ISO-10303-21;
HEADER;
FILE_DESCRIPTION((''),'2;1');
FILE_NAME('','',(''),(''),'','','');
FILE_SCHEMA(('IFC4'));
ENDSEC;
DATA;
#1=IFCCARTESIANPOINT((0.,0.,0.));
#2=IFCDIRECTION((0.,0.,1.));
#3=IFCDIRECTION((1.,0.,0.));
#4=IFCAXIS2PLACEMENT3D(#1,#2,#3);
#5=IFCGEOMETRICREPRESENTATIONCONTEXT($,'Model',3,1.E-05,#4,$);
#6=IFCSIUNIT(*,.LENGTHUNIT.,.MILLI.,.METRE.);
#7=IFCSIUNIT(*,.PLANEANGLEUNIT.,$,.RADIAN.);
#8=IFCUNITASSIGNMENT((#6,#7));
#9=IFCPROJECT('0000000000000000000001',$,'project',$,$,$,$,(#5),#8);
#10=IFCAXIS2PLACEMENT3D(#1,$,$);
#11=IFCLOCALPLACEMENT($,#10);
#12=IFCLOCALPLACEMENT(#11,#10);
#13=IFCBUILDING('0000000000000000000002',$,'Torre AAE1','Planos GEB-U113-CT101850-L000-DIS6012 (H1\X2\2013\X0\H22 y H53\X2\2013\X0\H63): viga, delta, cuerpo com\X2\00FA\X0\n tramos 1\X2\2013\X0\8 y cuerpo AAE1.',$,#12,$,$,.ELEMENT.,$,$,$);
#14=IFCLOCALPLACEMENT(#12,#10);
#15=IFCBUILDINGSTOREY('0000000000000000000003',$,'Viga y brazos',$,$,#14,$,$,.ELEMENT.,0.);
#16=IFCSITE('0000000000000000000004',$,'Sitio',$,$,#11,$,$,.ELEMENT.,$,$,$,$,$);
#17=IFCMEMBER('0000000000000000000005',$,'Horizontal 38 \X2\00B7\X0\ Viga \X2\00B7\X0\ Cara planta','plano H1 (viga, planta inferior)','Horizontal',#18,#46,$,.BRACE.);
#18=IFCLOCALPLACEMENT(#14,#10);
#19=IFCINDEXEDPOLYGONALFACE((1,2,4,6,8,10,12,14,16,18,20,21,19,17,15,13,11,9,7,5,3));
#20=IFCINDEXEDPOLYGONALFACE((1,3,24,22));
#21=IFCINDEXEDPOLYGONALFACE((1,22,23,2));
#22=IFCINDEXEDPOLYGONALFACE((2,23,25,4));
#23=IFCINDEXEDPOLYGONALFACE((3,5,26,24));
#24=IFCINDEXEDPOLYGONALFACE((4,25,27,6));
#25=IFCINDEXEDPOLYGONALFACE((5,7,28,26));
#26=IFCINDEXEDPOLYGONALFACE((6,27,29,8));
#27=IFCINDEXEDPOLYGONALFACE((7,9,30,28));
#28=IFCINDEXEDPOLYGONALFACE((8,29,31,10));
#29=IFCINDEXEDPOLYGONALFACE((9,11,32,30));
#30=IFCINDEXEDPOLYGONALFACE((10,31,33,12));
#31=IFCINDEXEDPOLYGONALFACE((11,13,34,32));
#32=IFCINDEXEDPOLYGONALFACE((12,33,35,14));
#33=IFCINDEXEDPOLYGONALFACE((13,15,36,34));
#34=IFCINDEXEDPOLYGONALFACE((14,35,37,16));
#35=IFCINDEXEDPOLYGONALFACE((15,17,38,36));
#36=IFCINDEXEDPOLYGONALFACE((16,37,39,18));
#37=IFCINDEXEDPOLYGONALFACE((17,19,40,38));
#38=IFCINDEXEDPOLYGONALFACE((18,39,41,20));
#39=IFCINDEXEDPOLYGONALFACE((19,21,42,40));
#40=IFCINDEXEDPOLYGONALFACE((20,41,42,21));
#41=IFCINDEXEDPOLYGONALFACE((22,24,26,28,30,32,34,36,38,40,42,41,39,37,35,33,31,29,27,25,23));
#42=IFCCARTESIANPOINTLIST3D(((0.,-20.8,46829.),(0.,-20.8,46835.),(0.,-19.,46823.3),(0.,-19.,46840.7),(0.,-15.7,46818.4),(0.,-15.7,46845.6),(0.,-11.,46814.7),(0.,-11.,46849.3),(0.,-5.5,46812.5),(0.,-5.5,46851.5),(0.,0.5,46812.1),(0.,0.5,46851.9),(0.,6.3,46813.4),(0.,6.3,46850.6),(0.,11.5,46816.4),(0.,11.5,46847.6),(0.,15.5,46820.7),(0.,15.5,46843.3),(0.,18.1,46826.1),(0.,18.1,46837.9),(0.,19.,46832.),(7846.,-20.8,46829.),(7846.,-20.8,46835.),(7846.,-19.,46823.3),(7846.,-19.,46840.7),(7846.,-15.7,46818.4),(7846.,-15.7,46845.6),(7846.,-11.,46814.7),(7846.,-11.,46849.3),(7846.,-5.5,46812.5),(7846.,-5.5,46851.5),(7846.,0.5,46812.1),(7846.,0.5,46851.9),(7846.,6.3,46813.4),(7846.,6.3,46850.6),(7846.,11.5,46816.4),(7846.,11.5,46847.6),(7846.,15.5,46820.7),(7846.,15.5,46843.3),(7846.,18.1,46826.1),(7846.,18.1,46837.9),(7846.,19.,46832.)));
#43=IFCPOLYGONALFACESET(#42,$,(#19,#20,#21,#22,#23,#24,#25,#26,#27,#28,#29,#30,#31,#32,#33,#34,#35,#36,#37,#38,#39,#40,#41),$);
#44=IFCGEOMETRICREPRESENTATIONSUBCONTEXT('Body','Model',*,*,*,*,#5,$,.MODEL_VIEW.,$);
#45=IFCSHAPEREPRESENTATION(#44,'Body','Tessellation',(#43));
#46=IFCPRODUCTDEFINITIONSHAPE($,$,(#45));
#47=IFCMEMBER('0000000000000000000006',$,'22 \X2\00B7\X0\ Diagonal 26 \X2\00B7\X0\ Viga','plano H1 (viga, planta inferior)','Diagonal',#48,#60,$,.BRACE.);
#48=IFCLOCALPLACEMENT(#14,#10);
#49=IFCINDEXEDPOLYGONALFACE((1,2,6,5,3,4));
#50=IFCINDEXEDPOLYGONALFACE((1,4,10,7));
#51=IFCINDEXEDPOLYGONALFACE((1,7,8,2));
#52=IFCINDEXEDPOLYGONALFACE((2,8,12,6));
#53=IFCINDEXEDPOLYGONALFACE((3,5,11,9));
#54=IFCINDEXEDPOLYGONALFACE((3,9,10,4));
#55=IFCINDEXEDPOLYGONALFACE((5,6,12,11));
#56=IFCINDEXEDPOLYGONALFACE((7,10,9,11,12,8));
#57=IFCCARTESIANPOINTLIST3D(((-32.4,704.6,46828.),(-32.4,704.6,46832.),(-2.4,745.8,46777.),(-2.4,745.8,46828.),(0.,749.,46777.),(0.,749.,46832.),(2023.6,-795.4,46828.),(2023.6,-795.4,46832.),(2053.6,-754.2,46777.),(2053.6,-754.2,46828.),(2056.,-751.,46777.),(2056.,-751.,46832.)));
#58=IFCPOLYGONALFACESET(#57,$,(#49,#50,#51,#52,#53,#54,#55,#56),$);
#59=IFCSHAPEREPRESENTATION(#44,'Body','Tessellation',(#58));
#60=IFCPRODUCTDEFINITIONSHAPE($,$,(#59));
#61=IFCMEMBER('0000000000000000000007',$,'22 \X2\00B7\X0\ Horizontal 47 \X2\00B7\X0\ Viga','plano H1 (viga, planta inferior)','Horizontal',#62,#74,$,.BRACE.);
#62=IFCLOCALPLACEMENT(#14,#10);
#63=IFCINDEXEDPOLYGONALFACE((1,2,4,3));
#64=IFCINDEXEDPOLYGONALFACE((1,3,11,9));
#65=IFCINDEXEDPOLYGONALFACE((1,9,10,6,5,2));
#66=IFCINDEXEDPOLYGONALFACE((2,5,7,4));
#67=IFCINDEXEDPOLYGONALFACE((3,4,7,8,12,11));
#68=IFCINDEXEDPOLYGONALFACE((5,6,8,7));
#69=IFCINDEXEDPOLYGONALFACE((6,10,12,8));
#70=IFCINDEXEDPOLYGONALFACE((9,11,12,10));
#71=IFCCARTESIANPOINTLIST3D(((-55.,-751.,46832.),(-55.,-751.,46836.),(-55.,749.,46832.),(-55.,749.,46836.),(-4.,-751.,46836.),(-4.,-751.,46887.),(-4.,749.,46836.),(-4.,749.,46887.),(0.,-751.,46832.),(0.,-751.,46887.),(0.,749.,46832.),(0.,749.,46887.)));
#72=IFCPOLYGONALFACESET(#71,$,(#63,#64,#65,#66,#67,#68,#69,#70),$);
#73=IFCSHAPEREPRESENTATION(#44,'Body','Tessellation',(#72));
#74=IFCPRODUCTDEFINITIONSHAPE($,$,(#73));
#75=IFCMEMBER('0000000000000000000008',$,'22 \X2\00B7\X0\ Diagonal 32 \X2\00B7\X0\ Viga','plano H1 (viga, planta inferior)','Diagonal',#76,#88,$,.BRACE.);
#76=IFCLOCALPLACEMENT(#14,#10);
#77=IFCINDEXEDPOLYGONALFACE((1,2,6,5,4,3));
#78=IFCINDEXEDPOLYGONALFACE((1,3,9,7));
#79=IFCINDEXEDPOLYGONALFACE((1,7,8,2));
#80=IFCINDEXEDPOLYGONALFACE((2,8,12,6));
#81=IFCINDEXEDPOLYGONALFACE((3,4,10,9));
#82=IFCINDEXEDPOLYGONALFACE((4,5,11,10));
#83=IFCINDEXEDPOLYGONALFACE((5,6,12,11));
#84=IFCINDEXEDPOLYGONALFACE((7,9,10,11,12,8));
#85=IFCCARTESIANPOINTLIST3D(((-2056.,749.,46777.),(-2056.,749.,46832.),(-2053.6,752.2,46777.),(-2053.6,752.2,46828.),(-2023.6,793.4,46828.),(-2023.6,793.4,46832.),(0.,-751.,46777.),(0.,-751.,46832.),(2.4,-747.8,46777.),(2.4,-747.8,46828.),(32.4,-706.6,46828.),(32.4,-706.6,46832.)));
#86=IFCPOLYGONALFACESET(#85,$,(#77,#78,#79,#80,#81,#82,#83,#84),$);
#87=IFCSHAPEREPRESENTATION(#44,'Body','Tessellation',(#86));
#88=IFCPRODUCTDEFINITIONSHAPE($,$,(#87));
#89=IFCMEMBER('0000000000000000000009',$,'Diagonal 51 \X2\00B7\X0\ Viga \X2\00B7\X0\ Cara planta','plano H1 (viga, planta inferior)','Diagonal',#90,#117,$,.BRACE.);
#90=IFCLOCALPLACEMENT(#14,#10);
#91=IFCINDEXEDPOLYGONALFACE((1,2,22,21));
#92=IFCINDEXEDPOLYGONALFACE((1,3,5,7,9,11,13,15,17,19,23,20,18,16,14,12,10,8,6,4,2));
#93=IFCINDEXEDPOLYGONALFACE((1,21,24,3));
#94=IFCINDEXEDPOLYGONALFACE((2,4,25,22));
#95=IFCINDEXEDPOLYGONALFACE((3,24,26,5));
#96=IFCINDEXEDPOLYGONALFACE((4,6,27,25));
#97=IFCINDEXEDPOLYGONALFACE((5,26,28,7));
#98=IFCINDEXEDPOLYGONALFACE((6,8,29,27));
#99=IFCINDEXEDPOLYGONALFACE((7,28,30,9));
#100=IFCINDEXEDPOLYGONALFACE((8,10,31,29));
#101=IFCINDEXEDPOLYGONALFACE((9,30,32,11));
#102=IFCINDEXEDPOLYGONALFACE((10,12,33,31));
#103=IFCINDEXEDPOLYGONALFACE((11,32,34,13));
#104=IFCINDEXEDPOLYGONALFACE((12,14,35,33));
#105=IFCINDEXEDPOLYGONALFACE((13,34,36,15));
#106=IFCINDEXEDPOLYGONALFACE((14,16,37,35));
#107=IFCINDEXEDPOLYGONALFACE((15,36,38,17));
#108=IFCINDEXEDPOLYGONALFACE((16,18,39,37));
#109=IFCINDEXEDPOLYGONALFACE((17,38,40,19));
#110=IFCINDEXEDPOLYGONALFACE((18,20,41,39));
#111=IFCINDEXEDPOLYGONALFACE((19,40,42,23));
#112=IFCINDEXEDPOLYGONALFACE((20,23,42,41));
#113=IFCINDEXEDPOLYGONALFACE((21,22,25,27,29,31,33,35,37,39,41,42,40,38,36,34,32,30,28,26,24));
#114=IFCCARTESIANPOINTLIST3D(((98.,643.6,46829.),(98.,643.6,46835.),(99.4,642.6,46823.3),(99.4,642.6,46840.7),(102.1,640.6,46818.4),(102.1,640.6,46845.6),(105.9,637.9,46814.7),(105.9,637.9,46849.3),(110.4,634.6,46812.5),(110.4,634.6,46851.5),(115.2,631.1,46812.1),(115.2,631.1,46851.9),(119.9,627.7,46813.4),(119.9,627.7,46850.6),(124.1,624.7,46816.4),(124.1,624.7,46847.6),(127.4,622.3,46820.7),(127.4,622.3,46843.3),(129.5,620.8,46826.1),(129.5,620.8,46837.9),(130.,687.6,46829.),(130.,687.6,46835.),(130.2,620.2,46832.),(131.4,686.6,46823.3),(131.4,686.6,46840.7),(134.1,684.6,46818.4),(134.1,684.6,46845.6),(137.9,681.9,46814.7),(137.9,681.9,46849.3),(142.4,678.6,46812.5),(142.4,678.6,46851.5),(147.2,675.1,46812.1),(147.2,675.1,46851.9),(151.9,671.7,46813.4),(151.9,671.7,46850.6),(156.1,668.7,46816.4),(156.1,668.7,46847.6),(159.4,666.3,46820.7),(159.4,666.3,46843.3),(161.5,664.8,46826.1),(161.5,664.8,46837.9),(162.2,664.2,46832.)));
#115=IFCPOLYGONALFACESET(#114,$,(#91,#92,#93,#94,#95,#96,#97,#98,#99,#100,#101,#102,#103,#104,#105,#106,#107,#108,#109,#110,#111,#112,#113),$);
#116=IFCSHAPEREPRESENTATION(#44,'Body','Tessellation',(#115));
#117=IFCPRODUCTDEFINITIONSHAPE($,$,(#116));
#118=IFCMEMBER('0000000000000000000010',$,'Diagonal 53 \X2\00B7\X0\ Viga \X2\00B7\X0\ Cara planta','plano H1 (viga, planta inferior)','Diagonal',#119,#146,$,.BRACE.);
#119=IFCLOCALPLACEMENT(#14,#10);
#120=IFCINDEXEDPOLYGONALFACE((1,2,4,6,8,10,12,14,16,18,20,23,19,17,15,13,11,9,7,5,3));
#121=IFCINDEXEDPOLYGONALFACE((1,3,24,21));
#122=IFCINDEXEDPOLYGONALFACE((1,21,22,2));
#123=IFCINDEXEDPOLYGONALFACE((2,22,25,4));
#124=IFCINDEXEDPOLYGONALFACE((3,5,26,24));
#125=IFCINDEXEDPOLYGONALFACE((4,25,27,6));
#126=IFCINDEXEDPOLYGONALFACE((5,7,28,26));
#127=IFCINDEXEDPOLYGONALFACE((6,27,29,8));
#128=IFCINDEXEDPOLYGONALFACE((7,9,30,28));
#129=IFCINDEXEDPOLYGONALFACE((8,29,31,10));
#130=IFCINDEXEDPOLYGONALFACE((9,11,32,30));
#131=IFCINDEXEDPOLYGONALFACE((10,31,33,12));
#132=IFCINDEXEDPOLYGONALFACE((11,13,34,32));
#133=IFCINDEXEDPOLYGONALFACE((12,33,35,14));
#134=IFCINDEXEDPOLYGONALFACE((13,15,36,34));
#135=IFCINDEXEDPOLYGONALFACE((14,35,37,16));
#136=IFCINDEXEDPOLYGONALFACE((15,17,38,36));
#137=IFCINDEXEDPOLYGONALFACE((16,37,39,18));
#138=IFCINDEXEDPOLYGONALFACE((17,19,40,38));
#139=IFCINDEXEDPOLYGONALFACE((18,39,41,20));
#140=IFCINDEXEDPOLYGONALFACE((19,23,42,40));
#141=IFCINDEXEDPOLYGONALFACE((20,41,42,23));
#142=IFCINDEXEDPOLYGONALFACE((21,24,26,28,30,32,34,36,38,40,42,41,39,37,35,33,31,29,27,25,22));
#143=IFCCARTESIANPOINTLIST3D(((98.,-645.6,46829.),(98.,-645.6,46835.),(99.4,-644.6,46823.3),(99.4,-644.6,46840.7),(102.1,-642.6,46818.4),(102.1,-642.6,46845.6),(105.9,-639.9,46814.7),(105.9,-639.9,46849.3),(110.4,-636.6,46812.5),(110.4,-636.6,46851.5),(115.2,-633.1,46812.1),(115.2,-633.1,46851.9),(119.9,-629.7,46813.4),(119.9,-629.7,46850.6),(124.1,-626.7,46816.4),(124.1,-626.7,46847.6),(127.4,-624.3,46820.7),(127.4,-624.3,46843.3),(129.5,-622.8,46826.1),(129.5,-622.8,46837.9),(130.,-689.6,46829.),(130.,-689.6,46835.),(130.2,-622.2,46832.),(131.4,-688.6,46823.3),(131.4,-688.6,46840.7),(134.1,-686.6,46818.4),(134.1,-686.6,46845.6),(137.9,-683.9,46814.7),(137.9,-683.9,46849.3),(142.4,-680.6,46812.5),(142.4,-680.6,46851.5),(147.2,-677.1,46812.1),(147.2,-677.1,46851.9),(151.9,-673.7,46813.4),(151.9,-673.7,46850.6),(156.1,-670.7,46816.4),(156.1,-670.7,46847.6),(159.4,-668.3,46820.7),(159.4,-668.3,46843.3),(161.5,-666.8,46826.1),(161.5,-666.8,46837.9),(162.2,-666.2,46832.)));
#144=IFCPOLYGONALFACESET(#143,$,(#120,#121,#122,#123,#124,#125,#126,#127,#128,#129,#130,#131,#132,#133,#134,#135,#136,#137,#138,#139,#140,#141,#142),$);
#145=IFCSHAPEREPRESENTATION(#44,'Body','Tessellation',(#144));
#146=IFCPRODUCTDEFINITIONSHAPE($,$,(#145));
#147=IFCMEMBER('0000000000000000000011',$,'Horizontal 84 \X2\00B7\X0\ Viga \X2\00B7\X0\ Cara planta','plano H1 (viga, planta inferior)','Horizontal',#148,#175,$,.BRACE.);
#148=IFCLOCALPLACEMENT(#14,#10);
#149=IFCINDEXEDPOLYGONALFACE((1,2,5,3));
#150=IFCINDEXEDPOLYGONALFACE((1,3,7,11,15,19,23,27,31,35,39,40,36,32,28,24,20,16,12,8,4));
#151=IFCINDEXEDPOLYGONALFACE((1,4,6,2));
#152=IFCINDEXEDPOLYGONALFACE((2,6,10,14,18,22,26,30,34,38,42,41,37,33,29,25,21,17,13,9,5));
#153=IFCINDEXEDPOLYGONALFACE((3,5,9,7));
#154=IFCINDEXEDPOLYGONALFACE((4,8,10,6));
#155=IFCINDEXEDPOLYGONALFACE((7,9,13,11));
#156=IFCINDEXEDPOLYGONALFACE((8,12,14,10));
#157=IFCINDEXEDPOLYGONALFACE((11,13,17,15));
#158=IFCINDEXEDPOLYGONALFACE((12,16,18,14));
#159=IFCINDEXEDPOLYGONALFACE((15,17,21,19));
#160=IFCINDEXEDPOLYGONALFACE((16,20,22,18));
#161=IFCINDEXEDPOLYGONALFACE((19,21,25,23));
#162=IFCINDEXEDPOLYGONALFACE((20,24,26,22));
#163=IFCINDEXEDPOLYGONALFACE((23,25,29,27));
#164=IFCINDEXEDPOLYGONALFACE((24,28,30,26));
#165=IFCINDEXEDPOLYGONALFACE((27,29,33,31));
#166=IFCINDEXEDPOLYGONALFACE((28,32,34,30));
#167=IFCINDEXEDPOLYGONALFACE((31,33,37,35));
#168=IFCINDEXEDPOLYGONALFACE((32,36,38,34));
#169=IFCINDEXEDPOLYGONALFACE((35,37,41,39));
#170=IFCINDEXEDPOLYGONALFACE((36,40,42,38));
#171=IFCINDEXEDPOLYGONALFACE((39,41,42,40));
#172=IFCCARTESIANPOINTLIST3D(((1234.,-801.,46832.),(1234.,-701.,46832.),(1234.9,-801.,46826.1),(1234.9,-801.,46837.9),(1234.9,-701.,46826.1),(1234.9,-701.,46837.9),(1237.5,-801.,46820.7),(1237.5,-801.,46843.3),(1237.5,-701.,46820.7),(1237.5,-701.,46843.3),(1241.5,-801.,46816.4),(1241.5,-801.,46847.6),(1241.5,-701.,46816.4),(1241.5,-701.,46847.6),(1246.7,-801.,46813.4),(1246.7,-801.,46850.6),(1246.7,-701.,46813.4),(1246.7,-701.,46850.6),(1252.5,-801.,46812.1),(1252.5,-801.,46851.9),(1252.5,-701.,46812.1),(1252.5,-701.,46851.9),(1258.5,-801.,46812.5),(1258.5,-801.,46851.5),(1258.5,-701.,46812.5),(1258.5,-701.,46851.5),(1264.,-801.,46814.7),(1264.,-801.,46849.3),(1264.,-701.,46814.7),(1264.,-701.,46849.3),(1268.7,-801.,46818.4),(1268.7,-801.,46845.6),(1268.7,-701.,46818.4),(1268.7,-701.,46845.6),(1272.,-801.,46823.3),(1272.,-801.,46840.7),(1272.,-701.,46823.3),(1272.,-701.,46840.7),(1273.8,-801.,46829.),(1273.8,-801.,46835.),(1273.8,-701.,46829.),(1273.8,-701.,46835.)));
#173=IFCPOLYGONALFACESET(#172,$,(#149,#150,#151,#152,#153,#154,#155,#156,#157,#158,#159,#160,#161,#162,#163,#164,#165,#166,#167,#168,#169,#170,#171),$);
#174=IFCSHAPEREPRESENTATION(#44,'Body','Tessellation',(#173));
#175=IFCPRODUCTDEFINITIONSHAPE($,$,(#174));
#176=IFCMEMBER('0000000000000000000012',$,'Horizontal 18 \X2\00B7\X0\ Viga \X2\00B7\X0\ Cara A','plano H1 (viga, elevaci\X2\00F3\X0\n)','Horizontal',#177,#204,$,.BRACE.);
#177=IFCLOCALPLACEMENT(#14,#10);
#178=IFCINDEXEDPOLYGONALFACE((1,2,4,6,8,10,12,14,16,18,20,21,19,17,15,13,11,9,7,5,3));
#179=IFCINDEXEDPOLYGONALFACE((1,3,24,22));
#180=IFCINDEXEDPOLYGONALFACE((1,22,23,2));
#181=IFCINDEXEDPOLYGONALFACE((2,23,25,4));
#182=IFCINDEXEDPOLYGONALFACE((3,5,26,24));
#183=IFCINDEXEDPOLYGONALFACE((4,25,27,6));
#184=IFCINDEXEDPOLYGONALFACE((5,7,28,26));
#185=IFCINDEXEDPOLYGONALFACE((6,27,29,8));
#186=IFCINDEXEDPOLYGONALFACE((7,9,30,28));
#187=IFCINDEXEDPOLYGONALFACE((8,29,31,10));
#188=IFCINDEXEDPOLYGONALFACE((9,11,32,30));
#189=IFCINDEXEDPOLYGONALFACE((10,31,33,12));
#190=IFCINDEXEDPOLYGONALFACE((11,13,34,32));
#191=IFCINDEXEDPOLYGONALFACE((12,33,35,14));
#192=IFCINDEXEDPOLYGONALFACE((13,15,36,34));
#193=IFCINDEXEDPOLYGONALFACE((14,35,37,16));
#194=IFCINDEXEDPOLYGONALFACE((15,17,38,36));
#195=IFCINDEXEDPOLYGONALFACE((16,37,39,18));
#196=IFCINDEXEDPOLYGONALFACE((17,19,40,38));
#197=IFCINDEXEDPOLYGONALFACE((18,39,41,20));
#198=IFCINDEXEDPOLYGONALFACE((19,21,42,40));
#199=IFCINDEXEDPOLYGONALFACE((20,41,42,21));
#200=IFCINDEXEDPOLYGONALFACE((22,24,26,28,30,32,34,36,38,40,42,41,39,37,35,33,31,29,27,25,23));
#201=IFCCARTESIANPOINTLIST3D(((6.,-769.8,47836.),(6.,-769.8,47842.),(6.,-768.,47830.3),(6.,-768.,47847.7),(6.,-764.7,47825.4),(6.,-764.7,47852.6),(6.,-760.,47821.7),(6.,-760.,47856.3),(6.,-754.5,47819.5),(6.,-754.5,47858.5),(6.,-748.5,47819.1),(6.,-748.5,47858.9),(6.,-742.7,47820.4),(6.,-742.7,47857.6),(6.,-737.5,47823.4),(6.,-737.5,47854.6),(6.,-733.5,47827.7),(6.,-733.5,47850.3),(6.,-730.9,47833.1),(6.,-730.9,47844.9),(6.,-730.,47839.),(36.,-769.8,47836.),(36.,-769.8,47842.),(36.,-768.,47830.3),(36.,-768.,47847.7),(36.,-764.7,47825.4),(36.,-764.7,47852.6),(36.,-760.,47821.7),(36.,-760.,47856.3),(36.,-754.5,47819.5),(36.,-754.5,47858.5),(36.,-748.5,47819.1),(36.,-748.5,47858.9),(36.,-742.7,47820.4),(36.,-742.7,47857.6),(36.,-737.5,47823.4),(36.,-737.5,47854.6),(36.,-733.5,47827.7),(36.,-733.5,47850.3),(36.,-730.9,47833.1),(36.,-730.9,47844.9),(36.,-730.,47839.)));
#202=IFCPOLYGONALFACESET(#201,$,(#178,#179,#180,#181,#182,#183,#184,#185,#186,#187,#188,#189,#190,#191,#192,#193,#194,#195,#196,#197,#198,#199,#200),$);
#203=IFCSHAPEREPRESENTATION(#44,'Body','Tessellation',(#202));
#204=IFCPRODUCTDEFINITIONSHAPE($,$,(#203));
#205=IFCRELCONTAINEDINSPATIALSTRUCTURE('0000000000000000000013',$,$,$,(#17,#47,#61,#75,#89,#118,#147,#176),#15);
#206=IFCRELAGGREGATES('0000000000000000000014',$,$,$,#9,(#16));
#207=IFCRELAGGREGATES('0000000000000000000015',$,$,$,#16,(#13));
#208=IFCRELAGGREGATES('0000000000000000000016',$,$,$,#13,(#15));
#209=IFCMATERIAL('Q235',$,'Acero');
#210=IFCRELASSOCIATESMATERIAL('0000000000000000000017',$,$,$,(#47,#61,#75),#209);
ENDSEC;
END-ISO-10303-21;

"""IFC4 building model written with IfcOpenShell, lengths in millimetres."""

from ifc_helpers import new_model, si_unit, frame, frame_2d, origin, origin_with_axes, place, context, subcontext, project, spatial, circle, l_section, extrude, material, element, save


model = new_model("IFC4")

# Units and contexts
model_context = context("Model", 3, precision=1e-05, world=origin_with_axes())
body_context = subcontext(model_context, "Body", "Model", "MODEL_VIEW")
ifc_project = project(units=[si_unit("LENGTHUNIT", "METRE", prefix="MILLI"), si_unit("PLANEANGLEUNIT", "RADIAN")], contexts=[model_context])

# Site, building, storey
site_placement = place(None, origin())
site = spatial("IfcSite", under=ifc_project, at=site_placement, Name="Sitio", CompositionType="ELEMENT")
building_placement = place(site_placement, origin())
building = spatial("IfcBuilding", under=site, at=building_placement, Name="Torre AAE1", Description="Planos GEB-U113-CT101850-L000-DIS6012 (H1–H22 y H53–H63): viga, delta, cuerpo común tramos 1–8 y cuerpo AAE1.", CompositionType="ELEMENT")
storey_placement = place(building_placement, origin())
storey = spatial("IfcBuildingStorey", under=building, at=storey_placement, Name="Viga y brazos", CompositionType="ELEMENT", Elevation=0.0)

# Members
ifc_material = material(Name="Q235", Category="Acero")
member_1_placement = place(storey_placement, frame((0.0, -1.0, 46832.0), z_axis=(1.0, 0.0, 0.0), x_axis=(0.0, 1.0, 0.0)))
element("IfcMember", 1, at=member_1_placement, inside=storey, Name="Horizontal 38 · Viga · Cara planta", Description="plano H1 (viga, planta inferior)", ObjectType="Horizontal", PredefinedType="BRACE", context=body_context, shape_type="SweptSolid", body=[
    extrude(circle(Radius=20.0), None, (0.0, 0.0, 1.0), 7846.0),
])
member_2_placement = place(storey_placement, frame((0.0, 749.0, 46832.0), z_axis=(0.807852, -0.589386, 0.0), x_axis=(-0.589386, -0.807852, 0.0)))
element("IfcMember", 2, at=member_2_placement, inside=storey, material=ifc_material, Name="22 · Diagonal 26 · Viga", Description="plano H1 (viga, planta inferior)", ObjectType="Diagonal", PredefinedType="BRACE", context=body_context, shape_type="SweptSolid", body=[
    extrude(l_section(Depth=55.0, Width=55.0, Thickness=4.0, at=frame_2d((27.5, 27.5))), None, (0.0, 0.0, 1.0), 2545.0),
])
member_3_placement = place(storey_placement, frame((0.0, 749.0, 46832.0), z_axis=(0.0, -1.0, 0.0), x_axis=(0.0, 0.0, 1.0)))
element("IfcMember", 3, at=member_3_placement, inside=storey, material=ifc_material, Name="22 · Horizontal 47 · Viga", Description="plano H1 (viga, planta inferior)", ObjectType="Horizontal", PredefinedType="BRACE", context=body_context, shape_type="SweptSolid", body=[
    extrude(l_section(Depth=55.0, Width=55.0, Thickness=4.0, at=frame_2d((27.5, 27.5))), None, (0.0, 0.0, 1.0), 1500.0),
])
member_4_placement = place(storey_placement, frame((0.0, -751.0, 46832.0), z_axis=(-0.807852, 0.589386, 0.0), x_axis=(0.589386, 0.807852, 0.0)))
element("IfcMember", 4, at=member_4_placement, inside=storey, material=ifc_material, Name="22 · Diagonal 32 · Viga", Description="plano H1 (viga, planta inferior)", ObjectType="Diagonal", PredefinedType="BRACE", context=body_context, shape_type="SweptSolid", body=[
    extrude(l_section(Depth=55.0, Width=55.0, Thickness=4.0, at=frame_2d((27.5, 27.5))), None, (0.0, 0.0, 1.0), 2545.0),
])
for number, where, z_axis, x_axis, name in (
    (5, (146.0, 676.0, 46832.0), (-0.588172, -0.808736, 0.0), (0.808736, -0.588172, 0.0), "Diagonal 51 · Viga · Cara planta"),
    (6, (146.0, -678.0, 46832.0), (-0.588172, 0.808736, 0.0), (0.808736, 0.588172, 0.0), "Diagonal 53 · Viga · Cara planta"),
):
    element("IfcMember", number, at=place(storey_placement, frame(where, z_axis=z_axis, x_axis=x_axis)), inside=storey, Name=name, Description="plano H1 (viga, planta inferior)", ObjectType="Diagonal", PredefinedType="BRACE", context=body_context, shape_type="SweptSolid", body=[
        extrude(circle(Radius=20.0), None, (0.0, 0.0, 1.0), 54.4),
    ])
member_5_placement = place(storey_placement, frame((1254.0, -701.0, 46832.0), z_axis=(0.0, -1.0, 0.0), x_axis=(-1.0, 0.0, 0.0)))
element("IfcMember", 7, at=member_5_placement, inside=storey, Name="Horizontal 84 · Viga · Cara planta", Description="plano H1 (viga, planta inferior)", ObjectType="Horizontal", PredefinedType="BRACE", context=body_context, shape_type="SweptSolid", body=[
    extrude(circle(Radius=20.0), None, (0.0, 0.0, 1.0), 100.0),
])
for number, where, z_axis, x_axis, name in (
    (8, (6.0, -750.0, 47839.0), (1.0, 0.0, 0.0), (0.0, 1.0, 0.0), "Horizontal 18 · Viga · Cara A"),
):
    element("IfcMember", number, at=place(storey_placement, frame(where, z_axis=z_axis, x_axis=x_axis)), inside=storey, Name=name, Description="plano H1 (viga, elevación)", ObjectType="Horizontal", PredefinedType="BRACE", context=body_context, shape_type="SweptSolid", body=[
        extrude(circle(Radius=20.0), None, (0.0, 0.0, 1.0), 30.0),
    ])

save(model, "model.ifc")
